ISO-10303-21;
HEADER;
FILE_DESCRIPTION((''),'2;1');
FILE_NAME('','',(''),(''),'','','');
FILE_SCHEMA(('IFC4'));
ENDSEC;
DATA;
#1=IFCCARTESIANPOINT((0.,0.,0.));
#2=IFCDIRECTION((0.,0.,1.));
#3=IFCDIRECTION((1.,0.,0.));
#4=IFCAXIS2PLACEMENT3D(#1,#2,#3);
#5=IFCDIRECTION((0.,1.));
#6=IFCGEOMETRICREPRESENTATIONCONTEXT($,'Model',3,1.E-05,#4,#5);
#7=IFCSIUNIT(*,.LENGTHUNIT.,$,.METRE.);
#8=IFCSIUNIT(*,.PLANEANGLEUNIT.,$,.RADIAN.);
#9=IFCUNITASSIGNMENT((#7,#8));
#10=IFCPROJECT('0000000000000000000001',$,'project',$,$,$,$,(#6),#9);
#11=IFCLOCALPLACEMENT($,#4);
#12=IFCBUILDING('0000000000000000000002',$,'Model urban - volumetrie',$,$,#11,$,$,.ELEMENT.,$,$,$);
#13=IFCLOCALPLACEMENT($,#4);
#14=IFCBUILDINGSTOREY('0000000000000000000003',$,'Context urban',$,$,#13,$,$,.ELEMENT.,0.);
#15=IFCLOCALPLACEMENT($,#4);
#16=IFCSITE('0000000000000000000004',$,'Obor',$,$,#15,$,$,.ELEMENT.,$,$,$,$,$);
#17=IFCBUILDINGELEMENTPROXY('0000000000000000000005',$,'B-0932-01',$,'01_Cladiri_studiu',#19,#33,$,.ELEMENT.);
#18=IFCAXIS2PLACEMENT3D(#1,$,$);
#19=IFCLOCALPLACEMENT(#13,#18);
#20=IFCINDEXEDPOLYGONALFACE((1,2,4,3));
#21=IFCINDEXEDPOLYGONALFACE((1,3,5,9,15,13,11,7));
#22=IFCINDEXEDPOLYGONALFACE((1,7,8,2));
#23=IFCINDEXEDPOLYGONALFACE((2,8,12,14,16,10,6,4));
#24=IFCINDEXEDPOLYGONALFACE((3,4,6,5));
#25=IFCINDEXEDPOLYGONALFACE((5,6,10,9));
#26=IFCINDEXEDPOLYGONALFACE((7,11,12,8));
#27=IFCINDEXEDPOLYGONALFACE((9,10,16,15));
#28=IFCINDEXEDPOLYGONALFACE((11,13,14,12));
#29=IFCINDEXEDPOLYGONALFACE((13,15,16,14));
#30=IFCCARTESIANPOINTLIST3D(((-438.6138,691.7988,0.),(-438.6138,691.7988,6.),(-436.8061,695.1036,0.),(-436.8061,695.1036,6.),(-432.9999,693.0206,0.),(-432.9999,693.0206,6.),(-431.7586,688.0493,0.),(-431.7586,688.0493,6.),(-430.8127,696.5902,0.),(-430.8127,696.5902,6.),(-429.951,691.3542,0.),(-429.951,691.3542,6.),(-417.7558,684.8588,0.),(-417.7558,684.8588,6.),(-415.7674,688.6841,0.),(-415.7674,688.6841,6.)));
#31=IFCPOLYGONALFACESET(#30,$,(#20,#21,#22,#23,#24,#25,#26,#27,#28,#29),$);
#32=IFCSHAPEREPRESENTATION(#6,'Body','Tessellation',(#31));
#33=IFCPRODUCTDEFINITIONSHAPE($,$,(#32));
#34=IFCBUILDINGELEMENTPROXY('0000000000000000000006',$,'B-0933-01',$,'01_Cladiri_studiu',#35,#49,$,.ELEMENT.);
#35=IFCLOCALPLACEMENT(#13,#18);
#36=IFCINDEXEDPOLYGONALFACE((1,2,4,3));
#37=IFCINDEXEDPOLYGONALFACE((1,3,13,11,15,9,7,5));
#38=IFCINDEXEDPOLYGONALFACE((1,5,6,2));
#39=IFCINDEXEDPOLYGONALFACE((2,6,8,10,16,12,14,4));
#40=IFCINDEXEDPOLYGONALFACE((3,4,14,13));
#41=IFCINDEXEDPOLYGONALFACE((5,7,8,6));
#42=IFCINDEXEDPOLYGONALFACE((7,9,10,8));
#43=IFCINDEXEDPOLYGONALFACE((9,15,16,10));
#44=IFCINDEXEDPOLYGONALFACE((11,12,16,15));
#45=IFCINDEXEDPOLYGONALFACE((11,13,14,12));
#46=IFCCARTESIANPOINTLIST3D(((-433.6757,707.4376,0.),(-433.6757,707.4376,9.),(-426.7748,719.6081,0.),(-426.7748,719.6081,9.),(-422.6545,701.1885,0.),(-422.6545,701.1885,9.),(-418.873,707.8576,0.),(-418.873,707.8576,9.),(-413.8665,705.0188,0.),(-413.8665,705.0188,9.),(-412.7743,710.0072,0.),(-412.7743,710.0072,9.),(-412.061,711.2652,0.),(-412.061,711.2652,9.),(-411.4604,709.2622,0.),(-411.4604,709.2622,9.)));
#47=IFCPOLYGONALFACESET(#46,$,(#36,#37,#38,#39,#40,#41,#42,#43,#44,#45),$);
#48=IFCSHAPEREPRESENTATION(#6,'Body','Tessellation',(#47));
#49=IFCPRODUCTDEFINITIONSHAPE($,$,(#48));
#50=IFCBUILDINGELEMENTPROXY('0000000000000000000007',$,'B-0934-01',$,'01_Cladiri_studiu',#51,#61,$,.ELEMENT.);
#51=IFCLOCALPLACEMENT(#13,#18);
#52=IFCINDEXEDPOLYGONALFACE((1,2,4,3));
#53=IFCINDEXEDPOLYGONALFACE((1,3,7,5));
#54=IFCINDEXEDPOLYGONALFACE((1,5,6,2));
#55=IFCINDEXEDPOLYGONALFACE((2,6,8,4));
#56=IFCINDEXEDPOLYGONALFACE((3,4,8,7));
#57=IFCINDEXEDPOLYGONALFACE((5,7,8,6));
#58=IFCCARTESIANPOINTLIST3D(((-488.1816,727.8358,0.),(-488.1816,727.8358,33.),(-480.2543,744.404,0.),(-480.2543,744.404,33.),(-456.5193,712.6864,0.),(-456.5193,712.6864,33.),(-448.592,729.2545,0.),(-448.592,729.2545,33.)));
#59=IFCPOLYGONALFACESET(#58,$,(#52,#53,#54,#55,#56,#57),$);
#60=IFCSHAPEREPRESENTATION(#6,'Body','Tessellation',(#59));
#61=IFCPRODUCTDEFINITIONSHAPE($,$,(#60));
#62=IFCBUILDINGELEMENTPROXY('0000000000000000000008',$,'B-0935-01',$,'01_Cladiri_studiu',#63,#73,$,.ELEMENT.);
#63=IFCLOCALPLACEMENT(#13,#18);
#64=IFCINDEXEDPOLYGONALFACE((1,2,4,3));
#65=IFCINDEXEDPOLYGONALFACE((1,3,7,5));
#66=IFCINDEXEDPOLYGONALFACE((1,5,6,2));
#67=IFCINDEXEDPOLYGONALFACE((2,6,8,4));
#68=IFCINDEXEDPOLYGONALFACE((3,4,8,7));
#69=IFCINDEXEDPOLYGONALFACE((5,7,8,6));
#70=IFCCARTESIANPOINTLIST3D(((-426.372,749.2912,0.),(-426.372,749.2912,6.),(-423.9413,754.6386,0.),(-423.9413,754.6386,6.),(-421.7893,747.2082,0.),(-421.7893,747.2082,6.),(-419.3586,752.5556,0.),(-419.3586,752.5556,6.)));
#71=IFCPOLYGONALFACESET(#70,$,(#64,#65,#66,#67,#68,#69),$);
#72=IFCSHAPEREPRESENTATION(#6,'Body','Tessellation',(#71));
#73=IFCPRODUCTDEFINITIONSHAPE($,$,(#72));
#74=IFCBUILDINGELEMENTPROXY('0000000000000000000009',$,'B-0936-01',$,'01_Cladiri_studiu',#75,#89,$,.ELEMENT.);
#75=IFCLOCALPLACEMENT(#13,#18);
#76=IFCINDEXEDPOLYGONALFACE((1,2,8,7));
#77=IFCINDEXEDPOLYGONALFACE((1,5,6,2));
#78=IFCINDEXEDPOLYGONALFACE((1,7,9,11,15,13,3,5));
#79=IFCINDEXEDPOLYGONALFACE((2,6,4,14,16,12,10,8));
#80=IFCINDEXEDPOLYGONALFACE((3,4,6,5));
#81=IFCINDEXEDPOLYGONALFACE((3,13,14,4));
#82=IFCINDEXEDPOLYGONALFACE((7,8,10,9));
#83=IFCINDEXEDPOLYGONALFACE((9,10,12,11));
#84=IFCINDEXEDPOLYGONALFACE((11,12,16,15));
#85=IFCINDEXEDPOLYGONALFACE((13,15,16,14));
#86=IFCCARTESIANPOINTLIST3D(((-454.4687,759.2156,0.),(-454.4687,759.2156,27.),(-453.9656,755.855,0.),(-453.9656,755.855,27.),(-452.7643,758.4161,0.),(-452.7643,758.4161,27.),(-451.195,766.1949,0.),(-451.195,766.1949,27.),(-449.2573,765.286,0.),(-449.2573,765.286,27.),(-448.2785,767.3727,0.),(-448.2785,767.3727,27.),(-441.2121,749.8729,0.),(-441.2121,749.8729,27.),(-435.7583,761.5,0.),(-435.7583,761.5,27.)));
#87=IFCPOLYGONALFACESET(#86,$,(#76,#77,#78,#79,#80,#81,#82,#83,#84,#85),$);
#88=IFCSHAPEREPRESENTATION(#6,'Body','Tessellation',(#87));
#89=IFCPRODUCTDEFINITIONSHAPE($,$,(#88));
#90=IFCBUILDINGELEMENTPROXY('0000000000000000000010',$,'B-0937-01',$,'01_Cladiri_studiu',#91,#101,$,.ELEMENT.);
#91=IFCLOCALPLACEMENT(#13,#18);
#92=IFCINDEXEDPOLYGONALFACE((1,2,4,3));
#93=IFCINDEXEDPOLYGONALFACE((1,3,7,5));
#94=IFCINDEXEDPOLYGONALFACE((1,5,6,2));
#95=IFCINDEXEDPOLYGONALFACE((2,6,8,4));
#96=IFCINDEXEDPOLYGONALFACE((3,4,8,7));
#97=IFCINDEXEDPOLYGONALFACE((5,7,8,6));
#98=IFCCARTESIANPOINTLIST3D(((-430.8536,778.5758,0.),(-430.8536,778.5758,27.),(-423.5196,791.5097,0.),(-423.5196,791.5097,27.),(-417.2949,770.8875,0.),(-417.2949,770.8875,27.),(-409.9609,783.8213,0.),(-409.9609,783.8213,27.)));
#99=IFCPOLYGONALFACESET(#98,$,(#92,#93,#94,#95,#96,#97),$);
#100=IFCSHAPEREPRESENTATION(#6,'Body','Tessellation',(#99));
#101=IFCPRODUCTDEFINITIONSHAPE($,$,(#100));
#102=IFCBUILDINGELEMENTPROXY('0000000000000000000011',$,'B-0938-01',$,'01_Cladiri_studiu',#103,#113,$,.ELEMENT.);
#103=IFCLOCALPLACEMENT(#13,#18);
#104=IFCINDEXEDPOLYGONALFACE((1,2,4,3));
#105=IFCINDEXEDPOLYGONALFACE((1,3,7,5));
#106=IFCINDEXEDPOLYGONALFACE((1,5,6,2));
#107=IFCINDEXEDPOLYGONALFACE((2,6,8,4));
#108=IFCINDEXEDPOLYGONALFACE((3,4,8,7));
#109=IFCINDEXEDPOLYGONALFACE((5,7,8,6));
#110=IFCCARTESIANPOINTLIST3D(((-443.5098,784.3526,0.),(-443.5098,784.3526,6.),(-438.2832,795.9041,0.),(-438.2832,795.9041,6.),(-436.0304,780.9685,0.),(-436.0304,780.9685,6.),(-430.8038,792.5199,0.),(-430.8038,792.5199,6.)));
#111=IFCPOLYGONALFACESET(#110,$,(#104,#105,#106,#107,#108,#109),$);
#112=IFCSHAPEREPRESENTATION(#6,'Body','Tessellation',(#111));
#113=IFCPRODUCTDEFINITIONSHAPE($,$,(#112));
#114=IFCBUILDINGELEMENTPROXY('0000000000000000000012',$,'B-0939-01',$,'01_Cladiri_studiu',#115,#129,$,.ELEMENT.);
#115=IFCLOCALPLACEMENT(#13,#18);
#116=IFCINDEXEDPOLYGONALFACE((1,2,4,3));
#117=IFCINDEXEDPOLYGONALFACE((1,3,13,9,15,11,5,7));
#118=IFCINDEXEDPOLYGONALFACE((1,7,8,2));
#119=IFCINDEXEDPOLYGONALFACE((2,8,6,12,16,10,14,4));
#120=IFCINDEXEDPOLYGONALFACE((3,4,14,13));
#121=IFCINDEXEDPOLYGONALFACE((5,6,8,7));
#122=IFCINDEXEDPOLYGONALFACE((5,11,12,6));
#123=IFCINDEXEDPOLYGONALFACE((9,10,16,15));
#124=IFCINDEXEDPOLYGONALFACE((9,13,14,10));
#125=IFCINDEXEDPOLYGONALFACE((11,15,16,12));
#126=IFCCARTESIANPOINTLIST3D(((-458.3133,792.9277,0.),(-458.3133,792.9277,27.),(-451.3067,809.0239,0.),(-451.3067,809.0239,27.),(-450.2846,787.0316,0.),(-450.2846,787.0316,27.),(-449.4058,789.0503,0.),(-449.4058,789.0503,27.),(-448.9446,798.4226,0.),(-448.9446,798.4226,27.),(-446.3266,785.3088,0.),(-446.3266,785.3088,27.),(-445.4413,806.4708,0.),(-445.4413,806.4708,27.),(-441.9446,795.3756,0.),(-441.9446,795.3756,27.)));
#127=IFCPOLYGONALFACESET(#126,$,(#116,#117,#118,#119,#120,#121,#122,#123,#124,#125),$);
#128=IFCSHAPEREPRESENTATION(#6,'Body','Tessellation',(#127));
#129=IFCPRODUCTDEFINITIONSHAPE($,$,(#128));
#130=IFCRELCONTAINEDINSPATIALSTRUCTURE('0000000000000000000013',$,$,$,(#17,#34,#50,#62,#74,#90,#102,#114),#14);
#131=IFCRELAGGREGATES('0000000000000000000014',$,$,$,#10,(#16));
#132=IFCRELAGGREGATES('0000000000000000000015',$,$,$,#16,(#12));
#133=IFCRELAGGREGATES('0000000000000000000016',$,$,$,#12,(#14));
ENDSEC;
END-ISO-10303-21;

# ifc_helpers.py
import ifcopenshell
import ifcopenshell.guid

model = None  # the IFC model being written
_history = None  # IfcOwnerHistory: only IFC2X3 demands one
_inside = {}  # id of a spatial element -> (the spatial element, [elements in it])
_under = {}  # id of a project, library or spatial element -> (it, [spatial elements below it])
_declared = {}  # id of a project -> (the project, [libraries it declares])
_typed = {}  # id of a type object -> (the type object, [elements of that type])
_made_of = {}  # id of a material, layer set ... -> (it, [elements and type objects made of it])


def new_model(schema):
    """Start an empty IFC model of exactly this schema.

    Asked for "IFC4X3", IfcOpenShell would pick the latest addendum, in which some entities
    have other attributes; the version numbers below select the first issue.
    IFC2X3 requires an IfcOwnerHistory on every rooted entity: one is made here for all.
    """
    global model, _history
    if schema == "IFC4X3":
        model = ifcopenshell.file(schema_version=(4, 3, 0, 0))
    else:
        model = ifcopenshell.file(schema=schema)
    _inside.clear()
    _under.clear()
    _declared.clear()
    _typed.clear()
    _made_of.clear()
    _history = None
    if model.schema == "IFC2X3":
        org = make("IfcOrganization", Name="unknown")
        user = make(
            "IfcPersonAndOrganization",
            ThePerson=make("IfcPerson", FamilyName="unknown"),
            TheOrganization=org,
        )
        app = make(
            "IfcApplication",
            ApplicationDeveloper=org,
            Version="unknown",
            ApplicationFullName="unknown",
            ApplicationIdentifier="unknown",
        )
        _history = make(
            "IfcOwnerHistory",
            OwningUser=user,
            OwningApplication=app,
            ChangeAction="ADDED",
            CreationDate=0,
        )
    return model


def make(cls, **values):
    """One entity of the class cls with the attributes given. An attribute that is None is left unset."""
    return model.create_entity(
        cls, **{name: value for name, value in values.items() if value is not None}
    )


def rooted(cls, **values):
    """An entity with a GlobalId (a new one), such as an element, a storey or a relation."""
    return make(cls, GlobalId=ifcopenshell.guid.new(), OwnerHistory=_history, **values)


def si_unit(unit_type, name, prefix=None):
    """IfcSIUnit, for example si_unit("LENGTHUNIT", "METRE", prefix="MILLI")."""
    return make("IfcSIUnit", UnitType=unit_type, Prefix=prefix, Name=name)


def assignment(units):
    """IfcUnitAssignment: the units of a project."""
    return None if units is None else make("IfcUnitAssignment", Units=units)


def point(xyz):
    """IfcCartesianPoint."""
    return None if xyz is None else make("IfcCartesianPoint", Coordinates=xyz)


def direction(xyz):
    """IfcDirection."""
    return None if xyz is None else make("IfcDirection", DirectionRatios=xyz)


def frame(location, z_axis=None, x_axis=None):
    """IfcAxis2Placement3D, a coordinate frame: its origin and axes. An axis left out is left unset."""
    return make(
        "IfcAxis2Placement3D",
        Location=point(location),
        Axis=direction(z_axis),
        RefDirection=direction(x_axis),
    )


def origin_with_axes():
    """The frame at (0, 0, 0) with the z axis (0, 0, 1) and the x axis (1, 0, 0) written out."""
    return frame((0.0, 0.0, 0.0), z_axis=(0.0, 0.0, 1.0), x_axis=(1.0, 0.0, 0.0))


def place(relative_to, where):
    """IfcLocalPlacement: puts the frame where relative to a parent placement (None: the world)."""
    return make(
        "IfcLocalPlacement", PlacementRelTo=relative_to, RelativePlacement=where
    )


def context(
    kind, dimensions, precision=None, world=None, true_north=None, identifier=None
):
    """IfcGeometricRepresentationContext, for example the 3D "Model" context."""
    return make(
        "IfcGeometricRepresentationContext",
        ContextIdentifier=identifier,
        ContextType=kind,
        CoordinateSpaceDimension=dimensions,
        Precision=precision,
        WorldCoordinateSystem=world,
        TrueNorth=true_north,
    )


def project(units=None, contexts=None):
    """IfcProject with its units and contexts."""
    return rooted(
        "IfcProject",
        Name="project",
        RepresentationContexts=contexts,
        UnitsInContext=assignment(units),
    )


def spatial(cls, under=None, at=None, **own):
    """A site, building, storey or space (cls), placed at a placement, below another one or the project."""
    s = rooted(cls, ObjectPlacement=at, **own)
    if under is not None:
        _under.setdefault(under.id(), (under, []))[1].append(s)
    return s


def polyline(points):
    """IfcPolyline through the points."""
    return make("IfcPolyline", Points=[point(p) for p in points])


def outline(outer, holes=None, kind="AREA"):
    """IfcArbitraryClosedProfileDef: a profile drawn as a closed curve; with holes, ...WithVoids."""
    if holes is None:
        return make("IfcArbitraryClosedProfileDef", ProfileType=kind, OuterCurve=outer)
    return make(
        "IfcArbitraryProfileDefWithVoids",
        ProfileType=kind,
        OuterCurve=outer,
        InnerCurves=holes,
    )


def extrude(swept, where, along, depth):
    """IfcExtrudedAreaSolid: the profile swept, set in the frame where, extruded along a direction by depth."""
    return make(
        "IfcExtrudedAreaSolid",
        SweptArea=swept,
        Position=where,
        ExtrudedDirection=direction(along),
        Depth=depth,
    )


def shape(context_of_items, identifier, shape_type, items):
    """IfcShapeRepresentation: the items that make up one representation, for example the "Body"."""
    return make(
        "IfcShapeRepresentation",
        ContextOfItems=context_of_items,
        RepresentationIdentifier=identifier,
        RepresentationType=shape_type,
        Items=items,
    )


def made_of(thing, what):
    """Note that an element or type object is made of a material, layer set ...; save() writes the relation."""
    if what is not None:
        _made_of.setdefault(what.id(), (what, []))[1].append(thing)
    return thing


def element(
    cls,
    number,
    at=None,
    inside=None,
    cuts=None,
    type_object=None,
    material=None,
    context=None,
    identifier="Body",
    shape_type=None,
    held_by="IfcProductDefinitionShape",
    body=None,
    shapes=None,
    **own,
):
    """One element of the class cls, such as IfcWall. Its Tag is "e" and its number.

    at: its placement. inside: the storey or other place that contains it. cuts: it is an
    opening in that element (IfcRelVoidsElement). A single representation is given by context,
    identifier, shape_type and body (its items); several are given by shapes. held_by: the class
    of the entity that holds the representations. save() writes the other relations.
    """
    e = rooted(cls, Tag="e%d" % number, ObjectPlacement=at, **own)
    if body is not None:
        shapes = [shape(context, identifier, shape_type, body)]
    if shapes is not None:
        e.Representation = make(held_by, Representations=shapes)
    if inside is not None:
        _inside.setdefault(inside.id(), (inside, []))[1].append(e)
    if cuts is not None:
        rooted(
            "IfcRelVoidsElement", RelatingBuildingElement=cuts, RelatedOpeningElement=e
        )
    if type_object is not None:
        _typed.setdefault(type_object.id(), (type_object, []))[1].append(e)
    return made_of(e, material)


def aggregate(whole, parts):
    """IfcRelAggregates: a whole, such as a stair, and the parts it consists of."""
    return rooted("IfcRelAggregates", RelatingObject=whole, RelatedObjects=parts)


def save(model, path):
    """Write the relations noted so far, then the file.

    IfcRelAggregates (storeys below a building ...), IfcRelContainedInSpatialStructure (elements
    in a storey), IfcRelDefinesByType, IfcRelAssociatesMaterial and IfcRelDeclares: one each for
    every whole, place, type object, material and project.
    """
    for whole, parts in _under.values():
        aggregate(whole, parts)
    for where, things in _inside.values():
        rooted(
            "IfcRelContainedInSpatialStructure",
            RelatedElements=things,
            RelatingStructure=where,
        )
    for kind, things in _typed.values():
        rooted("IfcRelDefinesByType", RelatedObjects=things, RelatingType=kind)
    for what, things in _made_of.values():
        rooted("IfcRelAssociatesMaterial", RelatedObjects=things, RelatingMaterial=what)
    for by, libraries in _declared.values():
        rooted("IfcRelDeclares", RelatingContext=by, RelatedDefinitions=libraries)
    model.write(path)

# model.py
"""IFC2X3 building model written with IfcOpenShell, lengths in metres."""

from ifc_helpers import new_model, si_unit, direction, origin_with_axes, place, context, project, spatial, polyline, outline, extrude, element, save


model = new_model("IFC2X3")

# Units and contexts
model_context = context("Model", 3, precision=1e-05, world=origin_with_axes(), true_north=direction((0.0, 1.0)))
ifc_project = project(units=[si_unit("LENGTHUNIT", "METRE"), si_unit("PLANEANGLEUNIT", "RADIAN")], contexts=[model_context])

# Site, building, storey
site_placement = place(None, origin_with_axes())
site = spatial("IfcSite", under=ifc_project, at=site_placement, Name="Obor", CompositionType="ELEMENT")
building_placement = place(None, origin_with_axes())
building = spatial("IfcBuilding", under=site, at=building_placement, Name="Model urban - volumetrie", CompositionType="ELEMENT")
storey_placement = place(None, origin_with_axes())
storey = spatial("IfcBuildingStorey", under=building, at=storey_placement, Name="Context urban", CompositionType="ELEMENT", Elevation=0.0)

# Building element proxies
proxy_1_placement = place(None, origin_with_axes())
element("IfcBuildingElementProxy", 1, at=proxy_1_placement, inside=storey, Name="B-0932-01", ObjectType="01_Cladiri_studiu", CompositionType="ELEMENT", context=model_context, shape_type="SweptSolid", body=[
    extrude(outline(polyline([(-436.8061, 695.1036), (-438.6138, 691.7988), (-431.7586, 688.0493), (-429.951, 691.3542), (-417.7558, 684.8588), (-415.7674, 688.6841), (-430.8127, 696.5902), (-432.9999, 693.0206), (-436.8061, 695.1036)])), origin_with_axes(), (0.0, 0.0, 1.0), 6.0),
])
proxy_2_placement = place(None, origin_with_axes())
element("IfcBuildingElementProxy", 2, at=proxy_2_placement, inside=storey, Name="B-0933-01", ObjectType="01_Cladiri_studiu", CompositionType="ELEMENT", context=model_context, shape_type="SweptSolid", body=[
    extrude(outline(polyline([(-412.7743, 710.0072), (-412.061, 711.2652), (-426.7748, 719.6081), (-433.6757, 707.4376), (-422.6545, 701.1885), (-418.873, 707.8576), (-413.8665, 705.0188), (-411.4604, 709.2622), (-412.7743, 710.0072)])), origin_with_axes(), (0.0, 0.0, 1.0), 9.0),
])
proxy_3_placement = place(None, origin_with_axes())
element("IfcBuildingElementProxy", 3, at=proxy_3_placement, inside=storey, Name="B-0934-01", ObjectType="01_Cladiri_studiu", CompositionType="ELEMENT", context=model_context, shape_type="SweptSolid", body=[
    extrude(outline(polyline([(-448.592, 729.2545), (-480.2543, 744.404), (-488.1816, 727.8358), (-456.5193, 712.6864), (-448.592, 729.2545)])), origin_with_axes(), (0.0, 0.0, 1.0), 33.0),
])
proxy_4_placement = place(None, origin_with_axes())
element("IfcBuildingElementProxy", 4, at=proxy_4_placement, inside=storey, Name="B-0935-01", ObjectType="01_Cladiri_studiu", CompositionType="ELEMENT", context=model_context, shape_type="SweptSolid", body=[
    extrude(outline(polyline([(-419.3586, 752.5556), (-423.9413, 754.6386), (-426.372, 749.2912), (-421.7893, 747.2082), (-419.3586, 752.5556)])), origin_with_axes(), (0.0, 0.0, 1.0), 6.0),
])
proxy_5_placement = place(None, origin_with_axes())
element("IfcBuildingElementProxy", 5, at=proxy_5_placement, inside=storey, Name="B-0936-01", ObjectType="01_Cladiri_studiu", CompositionType="ELEMENT", context=model_context, shape_type="SweptSolid", body=[
    extrude(outline(polyline([(-452.7643, 758.4161), (-453.9656, 755.855), (-441.2121, 749.8729), (-435.7583, 761.5), (-448.2785, 767.3727), (-449.2573, 765.286), (-451.195, 766.1949), (-454.4687, 759.2156), (-452.7643, 758.4161)])), origin_with_axes(), (0.0, 0.0, 1.0), 27.0),
])
proxy_6_placement = place(None, origin_with_axes())
element("IfcBuildingElementProxy", 6, at=proxy_6_placement, inside=storey, Name="B-0937-01", ObjectType="01_Cladiri_studiu", CompositionType="ELEMENT", context=model_context, shape_type="SweptSolid", body=[
    extrude(outline(polyline([(-417.2949, 770.8875), (-409.9609, 783.8213), (-423.5196, 791.5097), (-430.8536, 778.5758), (-417.2949, 770.8875)])), origin_with_axes(), (0.0, 0.0, 1.0), 27.0),
])
proxy_7_placement = place(None, origin_with_axes())
element("IfcBuildingElementProxy", 7, at=proxy_7_placement, inside=storey, Name="B-0938-01", ObjectType="01_Cladiri_studiu", CompositionType="ELEMENT", context=model_context, shape_type="SweptSolid", body=[
    extrude(outline(polyline([(-436.0304, 780.9685), (-430.8038, 792.5199), (-438.2832, 795.9041), (-443.5098, 784.3526), (-436.0304, 780.9685)])), origin_with_axes(), (0.0, 0.0, 1.0), 6.0),
])
proxy_8_placement = place(None, origin_with_axes())
element("IfcBuildingElementProxy", 8, at=proxy_8_placement, inside=storey, Name="B-0939-01", ObjectType="01_Cladiri_studiu", CompositionType="ELEMENT", context=model_context, shape_type="SweptSolid", body=[
    extrude(outline(polyline([(-458.3133, 792.9277), (-449.4058, 789.0503), (-450.2846, 787.0316), (-446.3266, 785.3088), (-441.9446, 795.3756), (-448.9446, 798.4226), (-445.4413, 806.4708), (-451.3067, 809.0239), (-458.3133, 792.9277)])), origin_with_axes(), (0.0, 0.0, 1.0), 27.0),
])

save(model, "model.ifc")
